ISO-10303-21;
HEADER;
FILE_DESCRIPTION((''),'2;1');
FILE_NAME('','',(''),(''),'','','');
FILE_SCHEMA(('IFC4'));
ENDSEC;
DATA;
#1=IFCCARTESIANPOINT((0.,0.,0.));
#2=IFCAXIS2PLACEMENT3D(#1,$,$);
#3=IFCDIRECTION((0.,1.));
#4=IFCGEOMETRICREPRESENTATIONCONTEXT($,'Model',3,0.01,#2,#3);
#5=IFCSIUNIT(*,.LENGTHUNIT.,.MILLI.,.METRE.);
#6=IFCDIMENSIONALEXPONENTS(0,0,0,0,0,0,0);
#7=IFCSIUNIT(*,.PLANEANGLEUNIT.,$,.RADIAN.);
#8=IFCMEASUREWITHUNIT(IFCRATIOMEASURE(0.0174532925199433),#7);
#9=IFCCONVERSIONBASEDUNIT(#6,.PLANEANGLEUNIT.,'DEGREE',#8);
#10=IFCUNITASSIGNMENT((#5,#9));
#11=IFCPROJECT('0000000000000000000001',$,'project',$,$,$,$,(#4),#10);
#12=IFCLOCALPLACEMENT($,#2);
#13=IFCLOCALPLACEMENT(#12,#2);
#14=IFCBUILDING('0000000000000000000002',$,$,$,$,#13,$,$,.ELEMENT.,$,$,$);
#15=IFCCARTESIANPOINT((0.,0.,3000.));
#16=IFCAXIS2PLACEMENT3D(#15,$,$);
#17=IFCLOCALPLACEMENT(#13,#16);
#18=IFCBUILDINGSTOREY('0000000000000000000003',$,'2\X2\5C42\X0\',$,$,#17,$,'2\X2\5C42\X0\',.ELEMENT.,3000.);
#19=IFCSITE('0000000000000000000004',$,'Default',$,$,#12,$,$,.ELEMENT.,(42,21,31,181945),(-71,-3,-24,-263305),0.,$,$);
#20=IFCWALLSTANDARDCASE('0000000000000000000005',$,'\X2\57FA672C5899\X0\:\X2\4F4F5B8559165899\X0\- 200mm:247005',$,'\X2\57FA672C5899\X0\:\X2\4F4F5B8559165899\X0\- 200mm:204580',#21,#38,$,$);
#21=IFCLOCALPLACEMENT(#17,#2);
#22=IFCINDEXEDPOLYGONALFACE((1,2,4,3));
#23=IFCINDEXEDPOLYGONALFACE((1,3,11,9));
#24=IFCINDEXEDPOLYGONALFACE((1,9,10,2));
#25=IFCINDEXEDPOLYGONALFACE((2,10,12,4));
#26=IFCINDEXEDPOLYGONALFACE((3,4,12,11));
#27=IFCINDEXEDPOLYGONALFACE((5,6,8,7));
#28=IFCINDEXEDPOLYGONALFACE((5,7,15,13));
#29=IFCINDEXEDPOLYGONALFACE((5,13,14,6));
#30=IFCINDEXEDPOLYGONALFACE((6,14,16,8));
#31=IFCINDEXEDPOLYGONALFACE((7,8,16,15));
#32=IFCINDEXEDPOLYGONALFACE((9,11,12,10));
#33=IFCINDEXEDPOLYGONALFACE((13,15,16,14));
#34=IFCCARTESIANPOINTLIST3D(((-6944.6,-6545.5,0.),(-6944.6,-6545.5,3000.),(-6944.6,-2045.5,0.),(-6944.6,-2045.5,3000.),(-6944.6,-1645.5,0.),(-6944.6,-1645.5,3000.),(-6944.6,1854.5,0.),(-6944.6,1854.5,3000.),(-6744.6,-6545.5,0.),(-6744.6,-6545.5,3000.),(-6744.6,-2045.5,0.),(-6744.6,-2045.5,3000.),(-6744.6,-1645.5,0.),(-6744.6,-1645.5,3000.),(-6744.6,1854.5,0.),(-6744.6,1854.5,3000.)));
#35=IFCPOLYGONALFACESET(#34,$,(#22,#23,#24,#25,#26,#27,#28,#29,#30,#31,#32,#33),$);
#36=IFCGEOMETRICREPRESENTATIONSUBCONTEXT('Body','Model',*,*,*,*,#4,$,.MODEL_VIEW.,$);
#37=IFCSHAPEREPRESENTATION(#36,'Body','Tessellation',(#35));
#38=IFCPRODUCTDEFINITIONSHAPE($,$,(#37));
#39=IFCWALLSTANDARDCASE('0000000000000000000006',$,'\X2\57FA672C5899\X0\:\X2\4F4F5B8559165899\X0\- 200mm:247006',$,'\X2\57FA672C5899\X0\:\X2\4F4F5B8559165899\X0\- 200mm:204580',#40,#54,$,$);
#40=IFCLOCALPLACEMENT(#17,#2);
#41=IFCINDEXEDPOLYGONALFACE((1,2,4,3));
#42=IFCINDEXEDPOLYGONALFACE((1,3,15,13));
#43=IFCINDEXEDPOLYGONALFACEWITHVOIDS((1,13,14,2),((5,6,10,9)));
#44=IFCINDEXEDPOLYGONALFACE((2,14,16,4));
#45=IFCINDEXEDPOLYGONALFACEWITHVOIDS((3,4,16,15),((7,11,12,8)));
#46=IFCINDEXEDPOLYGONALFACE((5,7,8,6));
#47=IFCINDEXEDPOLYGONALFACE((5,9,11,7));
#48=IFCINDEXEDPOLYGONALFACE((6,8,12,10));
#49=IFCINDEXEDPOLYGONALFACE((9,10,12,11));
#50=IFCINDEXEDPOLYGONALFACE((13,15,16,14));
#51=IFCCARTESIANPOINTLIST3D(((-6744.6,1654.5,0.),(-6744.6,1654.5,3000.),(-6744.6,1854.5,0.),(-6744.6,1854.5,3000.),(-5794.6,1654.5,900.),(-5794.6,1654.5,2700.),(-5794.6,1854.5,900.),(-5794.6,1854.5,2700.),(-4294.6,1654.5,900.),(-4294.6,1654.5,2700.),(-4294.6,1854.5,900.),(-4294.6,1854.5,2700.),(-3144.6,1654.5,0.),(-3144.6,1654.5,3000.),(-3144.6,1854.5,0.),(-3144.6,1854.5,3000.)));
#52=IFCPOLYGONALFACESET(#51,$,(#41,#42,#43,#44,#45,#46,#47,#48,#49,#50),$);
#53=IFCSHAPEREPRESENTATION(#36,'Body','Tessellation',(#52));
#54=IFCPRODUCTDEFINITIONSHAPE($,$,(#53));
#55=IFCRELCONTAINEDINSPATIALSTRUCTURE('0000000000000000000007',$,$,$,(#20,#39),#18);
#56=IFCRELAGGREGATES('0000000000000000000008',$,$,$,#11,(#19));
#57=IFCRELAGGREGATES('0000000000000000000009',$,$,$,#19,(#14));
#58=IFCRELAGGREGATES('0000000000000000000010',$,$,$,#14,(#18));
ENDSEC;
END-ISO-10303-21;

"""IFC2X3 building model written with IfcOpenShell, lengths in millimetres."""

from ifc_helpers import new_model, entity, si_unit, converted_unit, direction, frame, frame_2d, origin, place, context, subcontext, project, spatial, polyline, rectangle, extrude, clip, bounded_halfspace, element, save


model = new_model("IFC2X3")

# Units and contexts
model_context = context("Model", 3, precision=0.01, world=origin(), true_north=direction((0.0, 1.0)))
body_context = subcontext(model_context, "Body", "Model", "MODEL_VIEW")
ifc_project = project(units=[si_unit("LENGTHUNIT", "METRE", prefix="MILLI"), converted_unit("PLANEANGLEUNIT", "DEGREE", entity("IfcRatioMeasure", 0.0174532925199433), si_unit("PLANEANGLEUNIT", "RADIAN"), dimensions=[0, 0, 0, 0, 0, 0, 0])], contexts=[model_context])

# Site, building, storey
site_placement = place(None, origin())
site = spatial("IfcSite", under=ifc_project, at=site_placement, Name="Default", CompositionType="ELEMENT", RefLatitude=(42, 21, 31, 181945), RefLongitude=(-71, -3, -24, -263305), RefElevation=0.0)
building_placement = place(site_placement, origin())
building = spatial("IfcBuilding", under=site, at=building_placement, CompositionType="ELEMENT")
storey_placement = place(building_placement, frame((0.0, 0.0, 3000.0)))
storey = spatial("IfcBuildingStorey", under=building, at=storey_placement, Name="2层", LongName="2层", CompositionType="ELEMENT", Elevation=3000.0)

# Walls, openings
wall_1_placement = place(storey_placement, frame((-6844.6, -6545.5, 0.0), z_axis=(0.0, 0.0, 1.0), x_axis=(0.0, 1.0, 0.0)))
wall_1 = element("IfcWallStandardCase", 1, at=wall_1_placement, inside=storey, Name="基本墙:住宅外墙- 200mm:247005", ObjectType="基本墙:住宅外墙- 200mm:204580", context=body_context, shape_type="Clipping", body=[
    clip(extrude(rectangle(XDim=8400.0, YDim=200.0, at=frame_2d((4200.0, 0.0), x_axis=(-1.0, 0.0))), origin(), (0.0, 0.0, 1.0), 3000.0), bounded_halfspace(frame((0.0, -100.0, 0.0), z_axis=(1.0, 0.0, 0.0), x_axis=(0.0, 0.0, -1.0)), True, frame((0.0, -100.0, 0.0), z_axis=(1.0, 0.0, 0.0), x_axis=(0.0, 0.0, -1.0)), polyline([(0.0, 0.0), (0.0, 200.0), (-3000.0, 200.0), (-3000.0, 0.0), (0.0, 0.0)]))),
])
opening_1_placement = place(storey_placement, frame((-6844.6, -6545.5, 0.0), z_axis=(0.0, 0.0, 1.0), x_axis=(0.0, 1.0, 0.0)))
element("IfcOpeningElement", 2, at=opening_1_placement, cuts=wall_1, ObjectType="Opening", context=body_context, shape_type="SweptSolid", body=[
    extrude(rectangle(XDim=3000.0, YDim=200.0, at=frame_2d((0.0, 0.0), x_axis=(1.0, 0.0))), frame((4500.0, 0.0, 1500.0), z_axis=(1.0, 0.0, 0.0), x_axis=(0.0, 0.0, -1.0)), (0.0, 0.0, 1.0), 400.0),
])
wall_2_placement = place(storey_placement, frame((-6744.6, 1754.5, 0.0)))
wall_2 = element("IfcWallStandardCase", 3, at=wall_2_placement, inside=storey, Name="基本墙:住宅外墙- 200mm:247006", ObjectType="基本墙:住宅外墙- 200mm:204580", context=body_context, shape_type="SweptSolid", body=[
    extrude(rectangle(XDim=3600.0, YDim=200.0, at=frame_2d((1800.0, 0.0), x_axis=(-1.0, 0.0))), origin(), (0.0, 0.0, 1.0), 3000.0),
])
opening_2_placement = place(wall_2_placement, frame((950.0, -100.0, 900.0)))
element("IfcOpeningElement", 4, at=opening_2_placement, cuts=wall_2, ObjectType="Opening", context=body_context, shape_type="SweptSolid", body=[
    extrude(rectangle(XDim=1800.0, YDim=1500.0, at=frame_2d((900.0, 750.0), x_axis=(1.0, 0.0))), frame((0.0, 0.0, 0.0), z_axis=(0.0, 1.0, 0.0), x_axis=(0.0, 0.0, 1.0)), (0.0, 0.0, 1.0), 200.0),
])

save(model, "model.ifc")
